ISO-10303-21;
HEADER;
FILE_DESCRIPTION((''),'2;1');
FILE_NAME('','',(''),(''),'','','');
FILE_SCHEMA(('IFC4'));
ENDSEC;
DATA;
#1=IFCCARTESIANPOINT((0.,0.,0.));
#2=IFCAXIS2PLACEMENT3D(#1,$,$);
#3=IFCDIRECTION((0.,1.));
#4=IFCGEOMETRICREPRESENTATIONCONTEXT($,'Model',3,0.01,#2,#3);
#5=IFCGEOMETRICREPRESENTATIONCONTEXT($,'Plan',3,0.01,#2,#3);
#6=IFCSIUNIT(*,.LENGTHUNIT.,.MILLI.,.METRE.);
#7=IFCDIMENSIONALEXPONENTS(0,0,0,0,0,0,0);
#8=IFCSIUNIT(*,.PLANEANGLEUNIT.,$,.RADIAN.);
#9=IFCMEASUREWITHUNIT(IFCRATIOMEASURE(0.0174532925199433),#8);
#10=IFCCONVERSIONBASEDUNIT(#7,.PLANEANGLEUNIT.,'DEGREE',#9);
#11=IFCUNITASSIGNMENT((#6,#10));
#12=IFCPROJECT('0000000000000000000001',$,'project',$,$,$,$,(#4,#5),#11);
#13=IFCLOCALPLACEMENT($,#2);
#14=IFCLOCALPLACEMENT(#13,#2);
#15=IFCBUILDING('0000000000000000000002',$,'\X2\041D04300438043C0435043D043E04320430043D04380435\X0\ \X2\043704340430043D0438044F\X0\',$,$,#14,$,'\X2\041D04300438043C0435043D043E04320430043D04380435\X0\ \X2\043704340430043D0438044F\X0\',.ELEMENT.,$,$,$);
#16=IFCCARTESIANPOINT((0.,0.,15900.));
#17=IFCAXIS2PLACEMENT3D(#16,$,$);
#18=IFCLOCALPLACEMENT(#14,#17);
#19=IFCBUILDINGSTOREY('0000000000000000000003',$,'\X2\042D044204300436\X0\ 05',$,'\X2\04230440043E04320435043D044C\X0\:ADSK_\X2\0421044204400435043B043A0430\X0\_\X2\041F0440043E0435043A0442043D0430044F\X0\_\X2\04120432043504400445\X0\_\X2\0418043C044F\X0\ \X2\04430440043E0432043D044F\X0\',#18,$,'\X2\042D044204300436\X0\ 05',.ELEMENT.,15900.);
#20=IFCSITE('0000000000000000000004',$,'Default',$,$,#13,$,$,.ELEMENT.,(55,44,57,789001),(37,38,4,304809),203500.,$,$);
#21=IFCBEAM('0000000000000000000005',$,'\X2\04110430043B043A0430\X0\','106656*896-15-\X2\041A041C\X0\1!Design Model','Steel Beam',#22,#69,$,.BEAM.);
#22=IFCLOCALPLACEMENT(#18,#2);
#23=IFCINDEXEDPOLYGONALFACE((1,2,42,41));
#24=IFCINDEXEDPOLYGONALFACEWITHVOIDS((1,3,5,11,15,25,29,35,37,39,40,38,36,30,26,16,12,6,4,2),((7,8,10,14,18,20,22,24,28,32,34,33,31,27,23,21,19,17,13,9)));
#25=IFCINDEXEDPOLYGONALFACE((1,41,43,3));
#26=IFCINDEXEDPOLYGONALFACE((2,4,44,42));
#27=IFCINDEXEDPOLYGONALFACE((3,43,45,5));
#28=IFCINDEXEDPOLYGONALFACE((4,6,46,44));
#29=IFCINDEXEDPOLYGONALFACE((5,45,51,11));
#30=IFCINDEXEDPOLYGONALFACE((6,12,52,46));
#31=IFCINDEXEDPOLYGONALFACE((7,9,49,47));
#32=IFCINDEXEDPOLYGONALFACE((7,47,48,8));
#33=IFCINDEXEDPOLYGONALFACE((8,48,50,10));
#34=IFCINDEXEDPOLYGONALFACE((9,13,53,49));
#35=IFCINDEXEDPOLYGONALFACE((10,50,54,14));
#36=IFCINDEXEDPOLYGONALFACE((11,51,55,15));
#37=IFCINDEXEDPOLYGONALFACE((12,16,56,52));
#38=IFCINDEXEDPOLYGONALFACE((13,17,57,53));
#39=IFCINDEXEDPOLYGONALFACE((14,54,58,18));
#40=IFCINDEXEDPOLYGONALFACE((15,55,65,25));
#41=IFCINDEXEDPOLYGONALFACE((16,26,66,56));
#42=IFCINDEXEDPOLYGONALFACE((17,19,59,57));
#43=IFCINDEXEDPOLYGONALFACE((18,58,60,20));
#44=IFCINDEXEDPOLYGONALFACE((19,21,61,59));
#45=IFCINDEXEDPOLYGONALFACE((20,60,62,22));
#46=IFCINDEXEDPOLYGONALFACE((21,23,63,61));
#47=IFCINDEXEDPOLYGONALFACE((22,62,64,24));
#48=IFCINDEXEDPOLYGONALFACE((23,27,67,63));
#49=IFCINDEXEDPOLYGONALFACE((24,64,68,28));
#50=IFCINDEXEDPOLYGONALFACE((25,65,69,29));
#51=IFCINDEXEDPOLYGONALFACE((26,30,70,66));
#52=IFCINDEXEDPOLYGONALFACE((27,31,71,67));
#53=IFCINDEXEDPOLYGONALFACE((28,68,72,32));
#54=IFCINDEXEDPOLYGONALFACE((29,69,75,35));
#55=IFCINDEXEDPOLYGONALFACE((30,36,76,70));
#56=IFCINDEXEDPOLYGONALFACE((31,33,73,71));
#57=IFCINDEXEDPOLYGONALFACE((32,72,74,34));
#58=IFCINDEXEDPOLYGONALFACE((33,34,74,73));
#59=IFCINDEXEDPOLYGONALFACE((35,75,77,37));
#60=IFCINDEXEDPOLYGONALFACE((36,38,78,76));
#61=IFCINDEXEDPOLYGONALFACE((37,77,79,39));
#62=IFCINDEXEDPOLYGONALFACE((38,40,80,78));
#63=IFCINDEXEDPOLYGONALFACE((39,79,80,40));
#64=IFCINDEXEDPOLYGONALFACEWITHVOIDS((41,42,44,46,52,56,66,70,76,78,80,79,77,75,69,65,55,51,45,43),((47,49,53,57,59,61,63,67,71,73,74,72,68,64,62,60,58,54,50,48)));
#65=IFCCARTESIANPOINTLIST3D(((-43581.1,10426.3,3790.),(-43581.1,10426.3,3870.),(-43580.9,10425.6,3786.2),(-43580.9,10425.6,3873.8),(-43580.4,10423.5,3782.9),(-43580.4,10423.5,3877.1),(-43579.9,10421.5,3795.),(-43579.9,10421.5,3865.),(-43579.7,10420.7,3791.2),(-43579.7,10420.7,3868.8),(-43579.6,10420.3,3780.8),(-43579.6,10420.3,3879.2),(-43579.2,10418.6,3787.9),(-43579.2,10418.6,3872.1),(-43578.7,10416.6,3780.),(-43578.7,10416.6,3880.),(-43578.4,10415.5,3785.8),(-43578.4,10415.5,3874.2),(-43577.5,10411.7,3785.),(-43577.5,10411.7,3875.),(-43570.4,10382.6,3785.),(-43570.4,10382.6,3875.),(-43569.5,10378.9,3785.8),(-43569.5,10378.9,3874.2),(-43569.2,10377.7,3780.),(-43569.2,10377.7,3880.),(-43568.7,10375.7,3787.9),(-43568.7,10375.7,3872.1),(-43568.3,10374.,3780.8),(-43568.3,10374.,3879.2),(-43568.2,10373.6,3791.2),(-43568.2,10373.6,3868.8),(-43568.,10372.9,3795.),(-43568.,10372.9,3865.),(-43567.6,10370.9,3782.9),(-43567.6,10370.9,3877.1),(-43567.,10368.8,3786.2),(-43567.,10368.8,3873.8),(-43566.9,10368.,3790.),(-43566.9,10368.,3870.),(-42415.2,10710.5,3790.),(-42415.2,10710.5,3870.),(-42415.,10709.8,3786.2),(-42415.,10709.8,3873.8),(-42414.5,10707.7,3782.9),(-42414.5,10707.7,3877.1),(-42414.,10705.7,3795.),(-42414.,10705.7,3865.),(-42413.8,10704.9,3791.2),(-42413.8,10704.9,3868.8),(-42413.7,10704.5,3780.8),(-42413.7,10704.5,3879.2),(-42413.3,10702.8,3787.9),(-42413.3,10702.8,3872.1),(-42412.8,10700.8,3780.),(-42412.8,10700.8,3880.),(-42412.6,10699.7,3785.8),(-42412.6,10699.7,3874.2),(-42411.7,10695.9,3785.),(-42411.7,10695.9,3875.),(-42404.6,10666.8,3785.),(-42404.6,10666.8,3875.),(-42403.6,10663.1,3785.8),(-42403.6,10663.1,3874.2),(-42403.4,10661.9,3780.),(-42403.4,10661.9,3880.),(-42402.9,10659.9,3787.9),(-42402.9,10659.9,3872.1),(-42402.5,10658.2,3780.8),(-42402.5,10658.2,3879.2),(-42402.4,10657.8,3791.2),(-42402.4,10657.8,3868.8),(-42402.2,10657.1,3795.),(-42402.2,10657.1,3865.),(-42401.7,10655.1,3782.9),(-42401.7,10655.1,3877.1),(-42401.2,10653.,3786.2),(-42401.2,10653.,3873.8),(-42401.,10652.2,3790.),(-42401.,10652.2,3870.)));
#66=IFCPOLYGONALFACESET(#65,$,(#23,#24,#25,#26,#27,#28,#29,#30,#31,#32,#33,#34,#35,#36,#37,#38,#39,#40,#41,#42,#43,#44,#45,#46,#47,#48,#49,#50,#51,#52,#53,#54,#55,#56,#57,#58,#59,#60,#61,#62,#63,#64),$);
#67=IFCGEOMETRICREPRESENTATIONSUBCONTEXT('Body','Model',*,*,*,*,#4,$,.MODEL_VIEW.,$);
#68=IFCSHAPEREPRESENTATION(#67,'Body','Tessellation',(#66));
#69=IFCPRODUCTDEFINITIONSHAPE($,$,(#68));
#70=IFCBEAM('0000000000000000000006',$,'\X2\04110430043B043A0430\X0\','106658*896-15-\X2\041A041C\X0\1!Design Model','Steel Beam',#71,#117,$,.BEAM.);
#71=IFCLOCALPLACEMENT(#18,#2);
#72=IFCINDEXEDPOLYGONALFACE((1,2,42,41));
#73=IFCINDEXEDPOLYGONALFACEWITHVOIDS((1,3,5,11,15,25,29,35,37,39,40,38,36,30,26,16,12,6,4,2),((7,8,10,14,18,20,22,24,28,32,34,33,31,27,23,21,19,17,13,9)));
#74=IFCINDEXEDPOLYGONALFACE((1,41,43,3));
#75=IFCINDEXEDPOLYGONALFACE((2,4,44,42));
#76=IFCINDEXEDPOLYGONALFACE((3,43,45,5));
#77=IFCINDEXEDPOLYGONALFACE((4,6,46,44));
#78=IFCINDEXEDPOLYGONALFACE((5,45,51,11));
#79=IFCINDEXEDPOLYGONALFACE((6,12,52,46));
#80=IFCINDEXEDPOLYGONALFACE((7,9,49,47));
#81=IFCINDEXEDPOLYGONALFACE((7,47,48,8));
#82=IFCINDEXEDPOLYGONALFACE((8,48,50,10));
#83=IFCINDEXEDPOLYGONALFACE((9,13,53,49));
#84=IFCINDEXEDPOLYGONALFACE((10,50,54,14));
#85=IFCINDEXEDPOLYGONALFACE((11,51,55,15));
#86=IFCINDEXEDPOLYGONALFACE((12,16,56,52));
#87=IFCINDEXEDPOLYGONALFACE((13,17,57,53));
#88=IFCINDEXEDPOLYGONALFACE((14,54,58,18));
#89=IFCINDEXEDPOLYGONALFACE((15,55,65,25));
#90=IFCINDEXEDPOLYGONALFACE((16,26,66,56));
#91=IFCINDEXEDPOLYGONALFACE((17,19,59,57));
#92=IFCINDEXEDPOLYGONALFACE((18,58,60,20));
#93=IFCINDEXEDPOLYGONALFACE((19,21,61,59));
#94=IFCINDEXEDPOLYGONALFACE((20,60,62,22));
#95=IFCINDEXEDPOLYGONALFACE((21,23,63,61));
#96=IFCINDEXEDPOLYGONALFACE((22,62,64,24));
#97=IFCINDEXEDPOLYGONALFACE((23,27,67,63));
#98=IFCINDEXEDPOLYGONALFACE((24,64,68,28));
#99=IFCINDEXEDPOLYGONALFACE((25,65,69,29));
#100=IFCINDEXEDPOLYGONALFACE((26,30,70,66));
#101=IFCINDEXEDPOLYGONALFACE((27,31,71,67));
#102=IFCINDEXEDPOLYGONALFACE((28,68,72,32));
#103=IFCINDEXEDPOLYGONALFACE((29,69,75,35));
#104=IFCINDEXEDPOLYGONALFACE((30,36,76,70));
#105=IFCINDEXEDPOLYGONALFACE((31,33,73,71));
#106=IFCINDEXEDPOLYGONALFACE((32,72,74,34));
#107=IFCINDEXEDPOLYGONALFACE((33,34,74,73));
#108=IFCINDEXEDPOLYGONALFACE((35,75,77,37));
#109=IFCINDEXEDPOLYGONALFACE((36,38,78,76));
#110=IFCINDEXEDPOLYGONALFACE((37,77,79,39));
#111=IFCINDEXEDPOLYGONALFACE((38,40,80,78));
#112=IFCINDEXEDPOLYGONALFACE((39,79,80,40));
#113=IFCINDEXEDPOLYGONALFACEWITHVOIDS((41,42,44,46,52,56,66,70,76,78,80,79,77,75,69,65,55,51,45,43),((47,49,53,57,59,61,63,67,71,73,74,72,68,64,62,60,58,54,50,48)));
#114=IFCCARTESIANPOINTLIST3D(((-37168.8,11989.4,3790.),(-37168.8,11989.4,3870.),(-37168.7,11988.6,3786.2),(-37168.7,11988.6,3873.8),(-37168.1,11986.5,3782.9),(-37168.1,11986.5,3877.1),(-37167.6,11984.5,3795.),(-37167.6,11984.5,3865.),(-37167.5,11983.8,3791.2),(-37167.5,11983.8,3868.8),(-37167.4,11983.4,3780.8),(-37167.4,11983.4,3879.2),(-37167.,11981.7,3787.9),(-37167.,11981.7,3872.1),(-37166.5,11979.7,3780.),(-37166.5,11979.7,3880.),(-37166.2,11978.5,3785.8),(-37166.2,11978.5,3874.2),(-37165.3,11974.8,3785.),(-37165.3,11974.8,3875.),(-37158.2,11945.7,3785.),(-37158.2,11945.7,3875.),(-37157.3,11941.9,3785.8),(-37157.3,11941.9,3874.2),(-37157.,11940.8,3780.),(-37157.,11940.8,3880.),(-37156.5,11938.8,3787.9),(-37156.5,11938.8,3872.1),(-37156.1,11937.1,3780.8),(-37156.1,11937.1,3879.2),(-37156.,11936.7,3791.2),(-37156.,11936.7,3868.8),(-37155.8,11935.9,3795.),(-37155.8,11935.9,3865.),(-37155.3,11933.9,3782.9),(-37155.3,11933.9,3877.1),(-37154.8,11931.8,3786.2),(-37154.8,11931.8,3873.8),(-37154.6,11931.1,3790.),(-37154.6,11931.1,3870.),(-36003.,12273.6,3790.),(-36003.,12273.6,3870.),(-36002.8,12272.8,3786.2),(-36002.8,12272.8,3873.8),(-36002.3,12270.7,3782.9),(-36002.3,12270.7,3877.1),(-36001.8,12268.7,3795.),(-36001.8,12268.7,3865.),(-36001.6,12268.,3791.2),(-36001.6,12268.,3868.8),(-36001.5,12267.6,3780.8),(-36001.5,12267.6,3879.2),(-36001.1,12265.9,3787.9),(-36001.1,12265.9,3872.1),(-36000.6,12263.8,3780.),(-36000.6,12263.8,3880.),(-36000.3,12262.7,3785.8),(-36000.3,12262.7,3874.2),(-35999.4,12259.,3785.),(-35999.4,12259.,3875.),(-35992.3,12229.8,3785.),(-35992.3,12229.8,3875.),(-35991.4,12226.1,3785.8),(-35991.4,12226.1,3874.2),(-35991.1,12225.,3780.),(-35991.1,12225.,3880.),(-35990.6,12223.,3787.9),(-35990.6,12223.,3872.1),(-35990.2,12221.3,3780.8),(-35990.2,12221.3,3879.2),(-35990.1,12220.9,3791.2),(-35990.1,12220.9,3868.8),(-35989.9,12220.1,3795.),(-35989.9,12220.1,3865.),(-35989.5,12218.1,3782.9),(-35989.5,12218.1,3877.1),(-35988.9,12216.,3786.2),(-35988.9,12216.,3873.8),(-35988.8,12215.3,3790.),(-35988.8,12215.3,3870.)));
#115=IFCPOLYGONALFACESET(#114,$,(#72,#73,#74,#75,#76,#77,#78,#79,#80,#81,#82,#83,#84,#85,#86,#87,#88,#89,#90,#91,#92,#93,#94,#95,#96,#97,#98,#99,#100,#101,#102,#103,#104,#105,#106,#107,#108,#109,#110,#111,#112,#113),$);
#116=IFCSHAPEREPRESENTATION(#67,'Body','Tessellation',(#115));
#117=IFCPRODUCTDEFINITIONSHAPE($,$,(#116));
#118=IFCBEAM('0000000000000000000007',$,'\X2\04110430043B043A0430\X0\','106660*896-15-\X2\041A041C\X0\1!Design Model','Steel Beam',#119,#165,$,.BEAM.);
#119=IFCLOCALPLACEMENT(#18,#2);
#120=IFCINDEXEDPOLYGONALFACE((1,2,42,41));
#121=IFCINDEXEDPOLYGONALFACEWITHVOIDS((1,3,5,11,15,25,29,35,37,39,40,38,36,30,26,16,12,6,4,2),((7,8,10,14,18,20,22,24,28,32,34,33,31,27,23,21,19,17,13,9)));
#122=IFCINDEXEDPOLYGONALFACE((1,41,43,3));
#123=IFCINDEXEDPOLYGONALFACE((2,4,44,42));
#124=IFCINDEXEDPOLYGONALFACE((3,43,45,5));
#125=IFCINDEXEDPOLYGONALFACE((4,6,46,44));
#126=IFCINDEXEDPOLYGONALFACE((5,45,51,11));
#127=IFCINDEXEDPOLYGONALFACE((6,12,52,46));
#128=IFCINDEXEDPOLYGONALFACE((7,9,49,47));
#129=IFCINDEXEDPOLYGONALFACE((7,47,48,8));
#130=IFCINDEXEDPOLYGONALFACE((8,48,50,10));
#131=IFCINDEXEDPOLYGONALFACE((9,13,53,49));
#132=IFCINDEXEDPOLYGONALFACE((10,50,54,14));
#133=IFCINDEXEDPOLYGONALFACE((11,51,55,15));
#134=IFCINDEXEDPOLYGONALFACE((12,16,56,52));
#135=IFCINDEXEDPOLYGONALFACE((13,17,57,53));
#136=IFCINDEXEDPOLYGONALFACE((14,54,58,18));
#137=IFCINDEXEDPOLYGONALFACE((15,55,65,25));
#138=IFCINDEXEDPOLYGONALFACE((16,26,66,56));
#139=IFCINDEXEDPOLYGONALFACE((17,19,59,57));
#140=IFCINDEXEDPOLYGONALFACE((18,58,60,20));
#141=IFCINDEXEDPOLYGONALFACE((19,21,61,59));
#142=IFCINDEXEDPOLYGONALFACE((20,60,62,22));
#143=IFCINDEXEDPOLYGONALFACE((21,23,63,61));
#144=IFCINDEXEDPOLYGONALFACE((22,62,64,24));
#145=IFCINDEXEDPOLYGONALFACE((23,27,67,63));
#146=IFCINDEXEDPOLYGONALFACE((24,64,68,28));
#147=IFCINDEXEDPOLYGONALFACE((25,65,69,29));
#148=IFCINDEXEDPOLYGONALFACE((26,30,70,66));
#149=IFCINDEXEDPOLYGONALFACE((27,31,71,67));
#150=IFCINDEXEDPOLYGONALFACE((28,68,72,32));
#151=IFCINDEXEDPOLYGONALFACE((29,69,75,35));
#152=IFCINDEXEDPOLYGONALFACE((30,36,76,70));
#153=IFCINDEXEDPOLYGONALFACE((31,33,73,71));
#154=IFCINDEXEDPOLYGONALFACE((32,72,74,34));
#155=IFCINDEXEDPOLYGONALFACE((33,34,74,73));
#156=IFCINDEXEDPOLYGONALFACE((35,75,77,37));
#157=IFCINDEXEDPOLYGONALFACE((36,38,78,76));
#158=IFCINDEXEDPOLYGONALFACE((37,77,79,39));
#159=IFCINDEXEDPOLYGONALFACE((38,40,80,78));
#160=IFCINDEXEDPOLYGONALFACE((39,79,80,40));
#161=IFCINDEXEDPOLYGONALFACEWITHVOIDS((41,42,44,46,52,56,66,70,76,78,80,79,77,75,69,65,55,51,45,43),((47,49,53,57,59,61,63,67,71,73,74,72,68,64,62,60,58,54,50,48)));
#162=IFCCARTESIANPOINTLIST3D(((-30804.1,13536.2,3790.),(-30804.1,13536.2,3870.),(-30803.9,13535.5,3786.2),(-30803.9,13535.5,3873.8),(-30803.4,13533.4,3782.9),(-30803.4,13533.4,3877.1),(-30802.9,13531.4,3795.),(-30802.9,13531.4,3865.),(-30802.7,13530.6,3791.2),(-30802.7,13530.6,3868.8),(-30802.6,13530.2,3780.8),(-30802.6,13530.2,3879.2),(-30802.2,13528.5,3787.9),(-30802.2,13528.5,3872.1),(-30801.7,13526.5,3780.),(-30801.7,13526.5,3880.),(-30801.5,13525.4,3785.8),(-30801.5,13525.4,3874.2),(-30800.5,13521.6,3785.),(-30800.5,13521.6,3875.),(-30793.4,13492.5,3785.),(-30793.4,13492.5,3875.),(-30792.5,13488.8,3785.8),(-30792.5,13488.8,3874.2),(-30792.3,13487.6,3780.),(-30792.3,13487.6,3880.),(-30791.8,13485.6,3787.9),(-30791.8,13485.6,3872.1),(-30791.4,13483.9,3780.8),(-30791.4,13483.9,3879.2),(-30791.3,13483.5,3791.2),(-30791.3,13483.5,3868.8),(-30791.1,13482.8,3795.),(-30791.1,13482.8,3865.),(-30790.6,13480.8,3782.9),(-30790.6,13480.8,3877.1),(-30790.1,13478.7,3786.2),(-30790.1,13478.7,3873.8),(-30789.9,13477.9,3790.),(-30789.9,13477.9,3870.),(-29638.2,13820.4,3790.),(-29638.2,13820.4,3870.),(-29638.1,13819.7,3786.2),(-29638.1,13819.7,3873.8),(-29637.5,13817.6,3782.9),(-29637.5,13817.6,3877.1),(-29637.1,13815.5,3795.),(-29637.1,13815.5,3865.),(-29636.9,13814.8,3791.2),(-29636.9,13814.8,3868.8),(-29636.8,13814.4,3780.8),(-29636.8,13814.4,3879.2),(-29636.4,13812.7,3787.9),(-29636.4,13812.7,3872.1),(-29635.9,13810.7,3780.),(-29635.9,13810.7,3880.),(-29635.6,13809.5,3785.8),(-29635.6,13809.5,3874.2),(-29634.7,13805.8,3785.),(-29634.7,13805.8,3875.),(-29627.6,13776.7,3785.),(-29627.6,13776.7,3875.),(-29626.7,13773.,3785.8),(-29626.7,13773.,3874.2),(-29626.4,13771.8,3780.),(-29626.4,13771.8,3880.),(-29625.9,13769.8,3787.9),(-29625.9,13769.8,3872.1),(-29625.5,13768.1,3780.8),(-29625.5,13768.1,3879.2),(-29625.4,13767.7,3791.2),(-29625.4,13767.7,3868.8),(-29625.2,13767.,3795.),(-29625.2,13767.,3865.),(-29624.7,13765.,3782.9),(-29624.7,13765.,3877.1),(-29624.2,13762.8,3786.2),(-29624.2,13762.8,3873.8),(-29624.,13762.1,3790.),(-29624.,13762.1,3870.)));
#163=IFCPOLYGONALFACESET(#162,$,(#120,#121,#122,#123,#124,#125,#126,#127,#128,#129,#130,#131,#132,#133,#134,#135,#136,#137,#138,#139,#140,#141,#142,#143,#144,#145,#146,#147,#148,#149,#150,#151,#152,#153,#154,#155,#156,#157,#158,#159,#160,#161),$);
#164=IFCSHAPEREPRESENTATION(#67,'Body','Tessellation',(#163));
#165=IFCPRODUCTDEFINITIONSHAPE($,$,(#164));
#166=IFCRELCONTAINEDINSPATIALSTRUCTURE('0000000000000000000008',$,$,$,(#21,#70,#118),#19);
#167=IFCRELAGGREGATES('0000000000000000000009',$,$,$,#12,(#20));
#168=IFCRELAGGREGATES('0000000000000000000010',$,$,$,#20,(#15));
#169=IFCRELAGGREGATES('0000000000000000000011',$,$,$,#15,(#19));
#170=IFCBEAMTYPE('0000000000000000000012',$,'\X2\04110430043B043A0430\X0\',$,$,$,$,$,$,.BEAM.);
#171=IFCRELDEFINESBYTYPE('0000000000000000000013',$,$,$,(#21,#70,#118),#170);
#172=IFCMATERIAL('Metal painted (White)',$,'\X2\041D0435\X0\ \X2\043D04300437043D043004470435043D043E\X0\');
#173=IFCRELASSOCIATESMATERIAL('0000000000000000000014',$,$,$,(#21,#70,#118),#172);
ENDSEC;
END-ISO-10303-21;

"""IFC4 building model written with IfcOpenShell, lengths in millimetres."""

from ifc_helpers import new_model, entity, si_unit, converted_unit, direction, frame, origin, place, context, subcontext, project, spatial, indexed_curve, outline, extrude, material, type_object, element, save


model = new_model("IFC4")

# Units and contexts
model_context = context("Model", 3, precision=0.01, world=origin(), true_north=direction((0.0, 1.0)))
plan_context = context("Plan", 3, precision=0.01, world=origin(), true_north=direction((0.0, 1.0)))
body_context = subcontext(model_context, "Body", "Model", "MODEL_VIEW")
ifc_project = project(units=[si_unit("LENGTHUNIT", "METRE", prefix="MILLI"), converted_unit("PLANEANGLEUNIT", "DEGREE", entity("IfcRatioMeasure", 0.0174532925199433), si_unit("PLANEANGLEUNIT", "RADIAN"), dimensions=[0, 0, 0, 0, 0, 0, 0])], contexts=[model_context, plan_context])

# Site, building, storey
site_placement = place(None, origin())
site = spatial("IfcSite", under=ifc_project, at=site_placement, Name="Default", CompositionType="ELEMENT", RefLatitude=(55, 44, 57, 789001), RefLongitude=(37, 38, 4, 304809), RefElevation=203500.0)
building_placement = place(site_placement, origin())
building = spatial("IfcBuilding", under=site, at=building_placement, Name="Наименование здания", LongName="Наименование здания", CompositionType="ELEMENT")
storey_placement = place(building_placement, frame((0.0, 0.0, 15900.0)))
storey = spatial("IfcBuildingStorey", under=building, at=storey_placement, Name="Этаж 05", ObjectType="Уровень:ADSK_Стрелка_Проектная_Вверх_Имя уровня", LongName="Этаж 05", CompositionType="ELEMENT", Elevation=15900.0)

# Beams
ifc_material = material(Name="Metal painted (White)", Category="Не назначено")
beam_type = type_object("IfcBeamType", Name="Балка", PredefinedType="BEAM")
beam_1_placement = place(storey_placement, origin())
element("IfcBeam", 1, at=beam_1_placement, inside=storey, type_object=beam_type, material=ifc_material, Name="Балка", Description="106656*896-15-КМ1!Design Model", ObjectType="Steel Beam", PredefinedType="BEAM", context=body_context, shape_type="SweptSolid", body=[
    extrude(outline(indexed_curve([(9.9, -52.9), (13.8, -52.9), (17.4, -51.4), (20.1, -48.7), (21.6, -45.1), (37.2, 33.4), (37.2, 37.3), (35.7, 40.9), (33.0, 43.6), (29.4, 45.1), (-9.9, 52.9), (-13.8, 52.9), (-17.4, 51.4), (-20.1, 48.7), (-21.6, 45.1), (-37.2, -33.4), (-37.2, -37.3), (-35.7, -40.9), (-33.0, -43.6), (-29.4, -45.1), (9.9, -52.9)], self_intersect=False), holes=[indexed_curve([(-31.3, -29.5), (-17.7, 39.2), (-16.2, 42.8), (-13.4, 45.6), (-9.8, 47.1), (-5.9, 47.1), (23.5, 41.2), (27.1, 39.7), (29.9, 37.0), (31.3, 33.4), (31.3, 29.5), (17.7, -39.2), (16.2, -42.8), (13.4, -45.6), (9.8, -47.1), (5.9, -47.1), (-23.5, -41.2), (-27.1, -39.7), (-29.9, -37.0), (-31.3, -33.4), (-31.3, -29.5)], self_intersect=False)]), frame((-43574.0, 10397.2, 3830.0), z_axis=(0.971552, 0.236826, 0.0), x_axis=(-0.232276, 0.952884, 0.19509)), (0.0, 0.0, 1.0), 1200.0),
])
beam_2_placement = place(storey_placement, origin())
element("IfcBeam", 2, at=beam_2_placement, inside=storey, type_object=beam_type, material=ifc_material, Name="Балка", Description="106658*896-15-КМ1!Design Model", ObjectType="Steel Beam", PredefinedType="BEAM", context=body_context, shape_type="SweptSolid", body=[
    extrude(outline(indexed_curve([(9.9, -52.9), (13.8, -52.9), (17.4, -51.4), (20.1, -48.7), (21.6, -45.1), (37.2, 33.4), (37.2, 37.3), (35.7, 40.9), (33.0, 43.6), (29.4, 45.1), (-9.9, 52.9), (-13.8, 52.9), (-17.4, 51.4), (-20.1, 48.7), (-21.6, 45.1), (-37.2, -33.4), (-37.2, -37.3), (-35.7, -40.9), (-33.0, -43.6), (-29.4, -45.1), (9.9, -52.9)], self_intersect=False), holes=[indexed_curve([(-31.3, -29.5), (-17.7, 39.2), (-16.2, 42.8), (-13.4, 45.6), (-9.8, 47.1), (-5.9, 47.1), (23.5, 41.2), (27.1, 39.7), (29.9, 37.0), (31.3, 33.4), (31.3, 29.5), (17.7, -39.2), (16.2, -42.8), (13.4, -45.6), (9.8, -47.1), (5.9, -47.1), (-23.5, -41.2), (-27.1, -39.7), (-29.9, -37.0), (-31.3, -33.4), (-31.3, -29.5)], self_intersect=False)]), frame((-37161.7, 11960.2, 3830.0), z_axis=(0.971552, 0.236826, 0.0), x_axis=(-0.232276, 0.952884, 0.19509)), (0.0, 0.0, 1.0), 1200.0),
])
beam_3_placement = place(storey_placement, origin())
element("IfcBeam", 3, at=beam_3_placement, inside=storey, type_object=beam_type, material=ifc_material, Name="Балка", Description="106660*896-15-КМ1!Design Model", ObjectType="Steel Beam", PredefinedType="BEAM", context=body_context, shape_type="SweptSolid", body=[
    extrude(outline(indexed_curve([(9.9, -52.9), (13.8, -52.9), (17.4, -51.4), (20.1, -48.7), (21.6, -45.1), (37.2, 33.4), (37.2, 37.3), (35.7, 40.9), (33.0, 43.6), (29.4, 45.1), (-9.9, 52.9), (-13.8, 52.9), (-17.4, 51.4), (-20.1, 48.7), (-21.6, 45.1), (-37.2, -33.4), (-37.2, -37.3), (-35.7, -40.9), (-33.0, -43.6), (-29.4, -45.1), (9.9, -52.9)], self_intersect=False), holes=[indexed_curve([(-31.3, -29.5), (-17.7, 39.2), (-16.2, 42.8), (-13.4, 45.6), (-9.8, 47.1), (-5.9, 47.1), (23.5, 41.2), (27.1, 39.7), (29.9, 37.0), (31.3, 33.4), (31.3, 29.5), (17.7, -39.2), (16.2, -42.8), (13.4, -45.6), (9.8, -47.1), (5.9, -47.1), (-23.5, -41.2), (-27.1, -39.7), (-29.9, -37.0), (-31.3, -33.4), (-31.3, -29.5)], self_intersect=False)]), frame((-30797.0, 13507.1, 3830.0), z_axis=(0.971552, 0.236826, 0.0), x_axis=(-0.232276, 0.952884, 0.19509)), (0.0, 0.0, 1.0), 1200.0),
])

save(model, "model.ifc")
